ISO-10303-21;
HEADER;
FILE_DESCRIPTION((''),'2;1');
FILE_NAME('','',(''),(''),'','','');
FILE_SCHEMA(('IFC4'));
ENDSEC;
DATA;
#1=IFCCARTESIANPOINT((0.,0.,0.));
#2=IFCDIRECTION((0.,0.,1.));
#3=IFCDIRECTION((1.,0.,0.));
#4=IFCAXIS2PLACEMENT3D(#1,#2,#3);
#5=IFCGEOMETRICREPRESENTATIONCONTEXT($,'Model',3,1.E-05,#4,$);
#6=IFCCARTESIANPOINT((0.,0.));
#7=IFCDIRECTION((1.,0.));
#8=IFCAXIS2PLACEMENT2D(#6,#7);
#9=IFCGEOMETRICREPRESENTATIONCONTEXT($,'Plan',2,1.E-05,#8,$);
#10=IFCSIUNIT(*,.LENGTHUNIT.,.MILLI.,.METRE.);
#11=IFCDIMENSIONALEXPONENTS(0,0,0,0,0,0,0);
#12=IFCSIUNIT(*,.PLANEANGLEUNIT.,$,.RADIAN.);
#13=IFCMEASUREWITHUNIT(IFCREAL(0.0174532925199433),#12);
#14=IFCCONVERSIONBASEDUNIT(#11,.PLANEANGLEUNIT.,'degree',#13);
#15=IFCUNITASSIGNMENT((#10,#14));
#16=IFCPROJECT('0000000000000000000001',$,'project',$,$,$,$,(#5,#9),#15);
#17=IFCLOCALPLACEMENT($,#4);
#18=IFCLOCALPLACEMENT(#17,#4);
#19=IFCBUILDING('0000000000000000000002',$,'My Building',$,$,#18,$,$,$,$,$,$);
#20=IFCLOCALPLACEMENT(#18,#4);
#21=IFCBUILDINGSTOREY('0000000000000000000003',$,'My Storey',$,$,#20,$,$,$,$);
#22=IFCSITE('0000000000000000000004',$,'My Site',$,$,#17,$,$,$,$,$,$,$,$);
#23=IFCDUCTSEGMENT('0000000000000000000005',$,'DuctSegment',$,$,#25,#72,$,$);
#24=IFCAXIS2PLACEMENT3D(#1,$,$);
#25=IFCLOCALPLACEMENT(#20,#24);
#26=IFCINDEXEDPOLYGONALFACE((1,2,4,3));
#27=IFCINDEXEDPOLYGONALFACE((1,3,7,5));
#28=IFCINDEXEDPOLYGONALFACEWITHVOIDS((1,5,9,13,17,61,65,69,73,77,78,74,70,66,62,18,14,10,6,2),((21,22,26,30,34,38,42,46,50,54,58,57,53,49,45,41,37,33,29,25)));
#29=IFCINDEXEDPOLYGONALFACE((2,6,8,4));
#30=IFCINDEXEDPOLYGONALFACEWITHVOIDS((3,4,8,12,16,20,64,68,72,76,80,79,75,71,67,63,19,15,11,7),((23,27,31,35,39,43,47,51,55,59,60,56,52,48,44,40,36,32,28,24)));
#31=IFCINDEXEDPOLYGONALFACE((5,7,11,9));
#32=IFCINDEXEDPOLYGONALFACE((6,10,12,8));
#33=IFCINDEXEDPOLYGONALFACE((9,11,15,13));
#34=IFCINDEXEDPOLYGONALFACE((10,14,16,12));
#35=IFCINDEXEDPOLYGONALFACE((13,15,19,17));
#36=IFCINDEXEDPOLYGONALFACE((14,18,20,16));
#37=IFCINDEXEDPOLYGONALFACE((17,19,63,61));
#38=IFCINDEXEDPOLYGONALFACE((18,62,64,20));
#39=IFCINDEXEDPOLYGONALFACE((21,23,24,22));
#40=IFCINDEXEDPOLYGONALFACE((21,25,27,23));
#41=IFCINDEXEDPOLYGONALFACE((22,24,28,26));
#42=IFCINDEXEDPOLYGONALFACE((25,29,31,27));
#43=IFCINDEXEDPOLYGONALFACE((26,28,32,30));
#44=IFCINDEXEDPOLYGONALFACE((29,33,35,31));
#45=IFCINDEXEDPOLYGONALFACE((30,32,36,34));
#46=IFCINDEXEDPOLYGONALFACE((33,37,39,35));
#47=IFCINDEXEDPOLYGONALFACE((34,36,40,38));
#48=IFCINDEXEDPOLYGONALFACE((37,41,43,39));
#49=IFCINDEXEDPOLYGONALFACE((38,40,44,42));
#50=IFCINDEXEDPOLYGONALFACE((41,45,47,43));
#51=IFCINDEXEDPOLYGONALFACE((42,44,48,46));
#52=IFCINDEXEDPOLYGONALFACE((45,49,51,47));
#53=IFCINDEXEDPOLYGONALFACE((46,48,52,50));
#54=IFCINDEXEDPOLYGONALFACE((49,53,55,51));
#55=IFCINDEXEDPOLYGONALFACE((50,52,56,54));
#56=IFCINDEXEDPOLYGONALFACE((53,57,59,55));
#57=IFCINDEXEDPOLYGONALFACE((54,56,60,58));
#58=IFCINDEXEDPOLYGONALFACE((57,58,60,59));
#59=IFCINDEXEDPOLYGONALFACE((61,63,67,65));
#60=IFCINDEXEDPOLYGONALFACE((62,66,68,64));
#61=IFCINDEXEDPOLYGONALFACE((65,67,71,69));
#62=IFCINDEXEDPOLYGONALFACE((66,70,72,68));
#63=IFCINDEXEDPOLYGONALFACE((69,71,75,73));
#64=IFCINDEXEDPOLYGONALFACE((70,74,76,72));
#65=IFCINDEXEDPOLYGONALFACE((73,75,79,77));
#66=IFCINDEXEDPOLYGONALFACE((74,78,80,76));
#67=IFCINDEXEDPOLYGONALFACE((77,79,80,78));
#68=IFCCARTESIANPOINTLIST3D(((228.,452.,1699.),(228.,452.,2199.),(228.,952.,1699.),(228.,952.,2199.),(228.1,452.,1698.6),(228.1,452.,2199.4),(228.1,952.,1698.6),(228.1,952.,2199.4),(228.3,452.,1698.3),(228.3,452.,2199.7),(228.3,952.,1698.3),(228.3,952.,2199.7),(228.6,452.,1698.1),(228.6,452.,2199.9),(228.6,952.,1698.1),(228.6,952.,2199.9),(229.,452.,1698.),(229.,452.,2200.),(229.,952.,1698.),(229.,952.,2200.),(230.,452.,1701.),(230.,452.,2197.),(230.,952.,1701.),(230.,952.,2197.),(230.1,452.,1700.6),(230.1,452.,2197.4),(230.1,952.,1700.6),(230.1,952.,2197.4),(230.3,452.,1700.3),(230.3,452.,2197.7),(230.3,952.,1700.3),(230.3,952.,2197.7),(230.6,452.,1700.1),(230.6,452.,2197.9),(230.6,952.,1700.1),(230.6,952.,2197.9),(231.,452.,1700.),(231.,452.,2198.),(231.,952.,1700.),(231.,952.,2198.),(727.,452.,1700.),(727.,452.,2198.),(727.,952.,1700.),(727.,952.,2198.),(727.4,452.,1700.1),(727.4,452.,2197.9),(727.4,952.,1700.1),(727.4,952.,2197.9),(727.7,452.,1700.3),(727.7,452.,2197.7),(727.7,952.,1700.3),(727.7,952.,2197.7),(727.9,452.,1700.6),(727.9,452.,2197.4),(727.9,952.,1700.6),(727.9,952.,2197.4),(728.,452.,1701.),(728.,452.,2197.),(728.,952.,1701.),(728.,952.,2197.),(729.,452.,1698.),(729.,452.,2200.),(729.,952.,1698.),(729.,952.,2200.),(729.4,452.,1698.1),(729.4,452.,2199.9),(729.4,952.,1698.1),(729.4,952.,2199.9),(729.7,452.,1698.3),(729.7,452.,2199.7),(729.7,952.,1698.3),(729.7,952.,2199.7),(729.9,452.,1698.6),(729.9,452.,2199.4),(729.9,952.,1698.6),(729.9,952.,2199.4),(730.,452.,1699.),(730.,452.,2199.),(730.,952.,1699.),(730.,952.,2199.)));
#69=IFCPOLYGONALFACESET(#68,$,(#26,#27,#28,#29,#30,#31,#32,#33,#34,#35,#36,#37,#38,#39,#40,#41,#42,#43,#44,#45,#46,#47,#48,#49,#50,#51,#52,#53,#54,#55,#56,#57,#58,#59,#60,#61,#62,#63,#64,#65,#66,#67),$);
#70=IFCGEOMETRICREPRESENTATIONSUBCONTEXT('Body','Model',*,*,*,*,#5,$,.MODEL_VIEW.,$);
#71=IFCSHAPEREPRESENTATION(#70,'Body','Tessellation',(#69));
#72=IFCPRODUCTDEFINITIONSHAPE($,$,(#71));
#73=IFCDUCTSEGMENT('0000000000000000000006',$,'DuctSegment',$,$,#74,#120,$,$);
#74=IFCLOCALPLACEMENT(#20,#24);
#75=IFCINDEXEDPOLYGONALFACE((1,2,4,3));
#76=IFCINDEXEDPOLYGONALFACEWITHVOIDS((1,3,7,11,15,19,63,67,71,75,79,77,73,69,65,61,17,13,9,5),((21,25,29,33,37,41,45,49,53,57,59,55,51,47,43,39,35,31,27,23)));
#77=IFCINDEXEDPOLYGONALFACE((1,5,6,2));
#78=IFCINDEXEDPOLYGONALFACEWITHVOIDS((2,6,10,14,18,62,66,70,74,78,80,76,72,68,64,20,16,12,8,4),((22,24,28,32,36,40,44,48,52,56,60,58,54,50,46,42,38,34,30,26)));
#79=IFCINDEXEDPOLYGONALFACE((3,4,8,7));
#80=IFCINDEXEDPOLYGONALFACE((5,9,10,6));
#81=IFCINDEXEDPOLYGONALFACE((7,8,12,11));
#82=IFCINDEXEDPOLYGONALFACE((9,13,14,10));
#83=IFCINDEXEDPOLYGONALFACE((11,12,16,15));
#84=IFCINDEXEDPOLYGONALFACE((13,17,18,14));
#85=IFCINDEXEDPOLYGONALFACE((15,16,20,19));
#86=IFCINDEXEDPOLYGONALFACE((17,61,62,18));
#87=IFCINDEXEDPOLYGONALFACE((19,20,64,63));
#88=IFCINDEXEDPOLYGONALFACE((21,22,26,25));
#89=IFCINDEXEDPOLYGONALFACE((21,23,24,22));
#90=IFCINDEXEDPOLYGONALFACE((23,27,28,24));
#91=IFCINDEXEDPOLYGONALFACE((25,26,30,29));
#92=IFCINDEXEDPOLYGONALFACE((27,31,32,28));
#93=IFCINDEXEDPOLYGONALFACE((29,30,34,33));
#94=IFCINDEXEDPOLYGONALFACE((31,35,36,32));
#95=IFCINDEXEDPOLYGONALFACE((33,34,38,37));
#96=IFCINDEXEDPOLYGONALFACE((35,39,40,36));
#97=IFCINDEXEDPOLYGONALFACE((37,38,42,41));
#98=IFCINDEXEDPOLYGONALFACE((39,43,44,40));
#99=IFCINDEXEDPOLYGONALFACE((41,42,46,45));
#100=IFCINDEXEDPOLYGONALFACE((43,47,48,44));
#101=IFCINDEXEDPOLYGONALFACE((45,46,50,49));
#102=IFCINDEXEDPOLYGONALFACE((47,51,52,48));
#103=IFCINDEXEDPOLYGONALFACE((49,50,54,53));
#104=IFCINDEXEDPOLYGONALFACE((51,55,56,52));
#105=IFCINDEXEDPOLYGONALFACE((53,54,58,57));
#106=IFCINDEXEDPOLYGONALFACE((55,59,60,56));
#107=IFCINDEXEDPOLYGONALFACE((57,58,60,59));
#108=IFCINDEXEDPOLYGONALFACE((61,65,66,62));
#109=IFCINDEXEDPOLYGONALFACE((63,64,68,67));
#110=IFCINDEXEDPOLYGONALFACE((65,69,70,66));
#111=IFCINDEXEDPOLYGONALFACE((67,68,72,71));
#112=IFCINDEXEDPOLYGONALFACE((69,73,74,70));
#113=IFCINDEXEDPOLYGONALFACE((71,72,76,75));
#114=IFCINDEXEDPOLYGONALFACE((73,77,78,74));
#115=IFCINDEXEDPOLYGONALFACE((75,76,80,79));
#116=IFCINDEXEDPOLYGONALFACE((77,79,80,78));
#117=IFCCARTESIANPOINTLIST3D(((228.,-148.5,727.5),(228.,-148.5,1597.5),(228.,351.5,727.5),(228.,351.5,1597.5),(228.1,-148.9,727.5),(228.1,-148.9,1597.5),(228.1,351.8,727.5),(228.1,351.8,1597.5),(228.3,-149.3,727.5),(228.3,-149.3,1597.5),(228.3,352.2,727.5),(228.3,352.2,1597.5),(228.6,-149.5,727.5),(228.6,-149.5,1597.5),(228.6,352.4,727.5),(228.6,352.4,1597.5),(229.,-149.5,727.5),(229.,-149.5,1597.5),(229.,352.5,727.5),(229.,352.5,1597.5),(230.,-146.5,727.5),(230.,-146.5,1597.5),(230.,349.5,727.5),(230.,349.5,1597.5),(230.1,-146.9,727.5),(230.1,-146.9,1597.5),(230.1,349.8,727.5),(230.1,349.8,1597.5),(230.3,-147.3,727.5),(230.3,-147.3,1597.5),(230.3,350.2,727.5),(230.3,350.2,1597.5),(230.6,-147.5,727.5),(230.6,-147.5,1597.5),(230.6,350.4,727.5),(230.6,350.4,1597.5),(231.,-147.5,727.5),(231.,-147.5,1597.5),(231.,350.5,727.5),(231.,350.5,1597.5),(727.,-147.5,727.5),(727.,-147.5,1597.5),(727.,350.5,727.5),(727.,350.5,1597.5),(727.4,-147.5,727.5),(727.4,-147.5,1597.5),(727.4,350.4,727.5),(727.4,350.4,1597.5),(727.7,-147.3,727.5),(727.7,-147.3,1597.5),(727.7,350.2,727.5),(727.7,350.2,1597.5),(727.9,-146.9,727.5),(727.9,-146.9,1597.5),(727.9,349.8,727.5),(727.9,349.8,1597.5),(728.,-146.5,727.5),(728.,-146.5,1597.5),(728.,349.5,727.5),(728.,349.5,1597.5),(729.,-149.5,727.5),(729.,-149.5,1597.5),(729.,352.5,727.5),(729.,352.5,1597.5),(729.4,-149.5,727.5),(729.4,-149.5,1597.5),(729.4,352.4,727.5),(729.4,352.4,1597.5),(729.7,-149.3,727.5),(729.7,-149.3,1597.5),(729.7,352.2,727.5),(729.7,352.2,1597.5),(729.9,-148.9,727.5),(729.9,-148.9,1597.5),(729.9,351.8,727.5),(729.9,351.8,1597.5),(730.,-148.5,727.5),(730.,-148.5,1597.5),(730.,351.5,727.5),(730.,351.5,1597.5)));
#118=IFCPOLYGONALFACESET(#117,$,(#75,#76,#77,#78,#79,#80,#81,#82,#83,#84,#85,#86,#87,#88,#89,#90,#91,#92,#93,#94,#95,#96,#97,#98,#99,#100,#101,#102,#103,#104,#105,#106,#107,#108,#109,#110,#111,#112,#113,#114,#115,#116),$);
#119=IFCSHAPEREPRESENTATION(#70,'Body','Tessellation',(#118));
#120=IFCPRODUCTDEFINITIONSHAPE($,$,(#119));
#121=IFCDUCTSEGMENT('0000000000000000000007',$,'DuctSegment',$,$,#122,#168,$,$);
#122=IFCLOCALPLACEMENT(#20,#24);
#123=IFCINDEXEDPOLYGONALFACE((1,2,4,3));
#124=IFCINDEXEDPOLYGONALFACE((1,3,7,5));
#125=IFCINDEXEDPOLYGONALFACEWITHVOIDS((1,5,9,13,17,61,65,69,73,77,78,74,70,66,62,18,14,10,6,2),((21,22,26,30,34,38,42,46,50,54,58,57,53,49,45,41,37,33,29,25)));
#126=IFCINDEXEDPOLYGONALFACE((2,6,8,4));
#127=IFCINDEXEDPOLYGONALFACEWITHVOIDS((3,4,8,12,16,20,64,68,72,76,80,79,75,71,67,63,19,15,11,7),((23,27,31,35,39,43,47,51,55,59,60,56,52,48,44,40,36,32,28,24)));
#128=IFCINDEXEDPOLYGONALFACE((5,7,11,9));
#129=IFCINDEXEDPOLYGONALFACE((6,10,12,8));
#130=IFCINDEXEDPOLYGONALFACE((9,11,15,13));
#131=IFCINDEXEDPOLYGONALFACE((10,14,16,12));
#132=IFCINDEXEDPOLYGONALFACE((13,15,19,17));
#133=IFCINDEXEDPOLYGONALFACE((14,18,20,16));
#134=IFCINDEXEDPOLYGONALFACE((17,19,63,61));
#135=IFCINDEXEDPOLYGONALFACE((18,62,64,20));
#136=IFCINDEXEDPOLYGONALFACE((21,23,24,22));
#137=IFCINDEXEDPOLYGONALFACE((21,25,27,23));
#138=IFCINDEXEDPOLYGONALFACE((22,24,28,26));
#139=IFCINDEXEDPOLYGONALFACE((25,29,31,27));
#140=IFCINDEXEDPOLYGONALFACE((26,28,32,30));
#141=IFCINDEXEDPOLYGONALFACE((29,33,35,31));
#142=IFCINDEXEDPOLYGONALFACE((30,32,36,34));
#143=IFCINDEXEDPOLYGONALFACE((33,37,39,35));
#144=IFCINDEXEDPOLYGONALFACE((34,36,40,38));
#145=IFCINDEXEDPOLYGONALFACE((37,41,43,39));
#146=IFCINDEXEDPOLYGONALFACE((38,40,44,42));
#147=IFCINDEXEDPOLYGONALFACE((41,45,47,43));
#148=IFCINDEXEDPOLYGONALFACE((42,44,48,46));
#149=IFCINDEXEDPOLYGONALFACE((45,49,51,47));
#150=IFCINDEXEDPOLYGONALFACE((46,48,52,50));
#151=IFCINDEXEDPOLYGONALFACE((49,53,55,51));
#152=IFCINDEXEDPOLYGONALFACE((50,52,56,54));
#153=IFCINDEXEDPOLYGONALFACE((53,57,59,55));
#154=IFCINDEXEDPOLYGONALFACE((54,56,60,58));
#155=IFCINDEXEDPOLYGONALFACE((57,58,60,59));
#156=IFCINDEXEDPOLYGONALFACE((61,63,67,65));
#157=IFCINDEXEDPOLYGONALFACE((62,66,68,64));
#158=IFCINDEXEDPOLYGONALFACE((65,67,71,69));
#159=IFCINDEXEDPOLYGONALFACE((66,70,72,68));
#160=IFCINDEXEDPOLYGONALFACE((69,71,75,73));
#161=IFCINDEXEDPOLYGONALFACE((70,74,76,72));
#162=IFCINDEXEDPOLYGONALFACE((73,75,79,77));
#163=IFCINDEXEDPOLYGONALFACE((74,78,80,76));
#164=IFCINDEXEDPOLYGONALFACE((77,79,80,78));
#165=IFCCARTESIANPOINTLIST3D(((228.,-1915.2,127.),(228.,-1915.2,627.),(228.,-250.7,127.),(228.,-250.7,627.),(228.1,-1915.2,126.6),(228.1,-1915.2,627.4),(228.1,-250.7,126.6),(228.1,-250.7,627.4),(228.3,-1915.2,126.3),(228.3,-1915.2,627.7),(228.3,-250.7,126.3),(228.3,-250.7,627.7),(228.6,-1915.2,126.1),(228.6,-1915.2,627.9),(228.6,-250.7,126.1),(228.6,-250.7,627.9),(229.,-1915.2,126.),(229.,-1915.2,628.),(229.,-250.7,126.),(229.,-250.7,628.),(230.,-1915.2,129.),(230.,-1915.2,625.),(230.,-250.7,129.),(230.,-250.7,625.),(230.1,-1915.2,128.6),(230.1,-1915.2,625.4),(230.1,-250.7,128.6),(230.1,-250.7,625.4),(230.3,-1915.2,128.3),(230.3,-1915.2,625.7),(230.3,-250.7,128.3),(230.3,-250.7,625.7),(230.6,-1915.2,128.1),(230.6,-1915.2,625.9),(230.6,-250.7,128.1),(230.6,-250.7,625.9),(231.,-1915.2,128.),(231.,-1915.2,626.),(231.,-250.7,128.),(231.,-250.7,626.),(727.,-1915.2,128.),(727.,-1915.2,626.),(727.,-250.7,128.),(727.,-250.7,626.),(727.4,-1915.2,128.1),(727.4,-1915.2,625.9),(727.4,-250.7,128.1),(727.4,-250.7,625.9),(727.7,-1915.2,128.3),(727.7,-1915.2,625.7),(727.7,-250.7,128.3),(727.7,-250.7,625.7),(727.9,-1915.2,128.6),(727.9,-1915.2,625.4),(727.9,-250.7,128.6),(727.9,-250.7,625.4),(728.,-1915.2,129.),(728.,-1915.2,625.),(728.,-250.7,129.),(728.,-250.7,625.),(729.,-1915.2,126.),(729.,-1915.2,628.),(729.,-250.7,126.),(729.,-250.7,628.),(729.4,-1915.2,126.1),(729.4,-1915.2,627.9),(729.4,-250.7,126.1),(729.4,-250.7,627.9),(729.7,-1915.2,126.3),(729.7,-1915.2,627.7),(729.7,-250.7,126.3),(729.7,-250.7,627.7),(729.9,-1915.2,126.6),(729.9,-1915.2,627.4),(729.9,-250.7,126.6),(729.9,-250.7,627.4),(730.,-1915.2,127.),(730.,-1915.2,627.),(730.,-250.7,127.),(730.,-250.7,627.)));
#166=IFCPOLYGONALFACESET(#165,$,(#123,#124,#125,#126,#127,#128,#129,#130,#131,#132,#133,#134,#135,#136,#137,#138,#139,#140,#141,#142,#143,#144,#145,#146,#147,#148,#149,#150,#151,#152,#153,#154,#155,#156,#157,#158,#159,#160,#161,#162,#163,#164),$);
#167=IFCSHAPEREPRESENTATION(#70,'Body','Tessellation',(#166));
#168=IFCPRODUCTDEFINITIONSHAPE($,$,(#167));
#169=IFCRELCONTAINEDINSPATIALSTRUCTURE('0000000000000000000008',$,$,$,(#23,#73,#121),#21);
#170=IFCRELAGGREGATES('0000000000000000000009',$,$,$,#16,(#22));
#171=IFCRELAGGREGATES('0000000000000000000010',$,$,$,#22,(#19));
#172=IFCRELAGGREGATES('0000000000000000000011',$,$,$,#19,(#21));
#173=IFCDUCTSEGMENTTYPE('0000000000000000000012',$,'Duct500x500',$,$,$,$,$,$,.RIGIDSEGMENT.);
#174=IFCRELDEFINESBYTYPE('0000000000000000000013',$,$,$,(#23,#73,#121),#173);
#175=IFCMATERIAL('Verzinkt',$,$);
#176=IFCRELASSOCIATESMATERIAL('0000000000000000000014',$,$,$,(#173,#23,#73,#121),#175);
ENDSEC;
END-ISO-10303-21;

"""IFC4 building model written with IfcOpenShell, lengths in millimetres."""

from ifc_helpers import new_model, entity, si_unit, converted_unit, frame, origin_with_axes, origin_2d_with_axis, place, context, subcontext, project, spatial, hollow_rectangle, extrude, material, material_profile, profile_set, profile_usage, type_object, element, save


model = new_model("IFC4")

# Units and contexts
model_context = context("Model", 3, precision=1e-05, world=origin_with_axes())
plan_context = context("Plan", 2, precision=1e-05, world=origin_2d_with_axis())
body_context = subcontext(model_context, "Body", "Model", "MODEL_VIEW")
ifc_project = project(units=[si_unit("LENGTHUNIT", "METRE", prefix="MILLI"), converted_unit("PLANEANGLEUNIT", "degree", entity("IfcReal", 0.0174532925199433), si_unit("PLANEANGLEUNIT", "RADIAN"), dimensions=[0, 0, 0, 0, 0, 0, 0])], contexts=[model_context, plan_context])

# Site, building, storey
site_placement = place(None, origin_with_axes())
site = spatial("IfcSite", under=ifc_project, at=site_placement, Name="My Site")
building_placement = place(site_placement, origin_with_axes())
building = spatial("IfcBuilding", under=site, at=building_placement, Name="My Building")
storey_placement = place(building_placement, origin_with_axes())
storey = spatial("IfcBuildingStorey", under=building, at=storey_placement, Name="My Storey")

# Shared definitions
ifc_material = material(Name="Verzinkt")

# Duct segments
ifc_material_profile_1 = material_profile(ifc_material, hollow_rectangle(XDim=502.0, YDim=502.0, WallThickness=2.0, InnerFilletRadius=1.0, OuterFilletRadius=1.0))
ifc_profile_set_1 = profile_set([ifc_material_profile_1])
duct_segment_type_1 = type_object("IfcDuctSegmentType", Name="Duct500x500", PredefinedType="RIGIDSEGMENT", material=ifc_profile_set_1)
ifc_profile_usage_1 = profile_usage(ifc_profile_set_1, cardinal=5)
duct_segment_1_placement = place(storey_placement, frame((479.0, 952.0, 1949.0), z_axis=(0.0, -1.0, 0.0), x_axis=(1.0, 0.0, 0.0)))
element("IfcDuctSegment", 1, at=duct_segment_1_placement, inside=storey, type_object=duct_segment_type_1, material=ifc_profile_usage_1, Name="DuctSegment", context=body_context, shape_type="SweptSolid", body=[
    extrude(hollow_rectangle(XDim=502.0, YDim=502.0, WallThickness=2.0, InnerFilletRadius=1.0, OuterFilletRadius=1.0), origin_with_axes(), (0.0, 0.0, 1.0), 500.0),
])
ifc_profile_usage_2 = profile_usage(ifc_profile_set_1, cardinal=5)
duct_segment_2_placement = place(storey_placement, frame((479.0, 101.5, 1597.5), z_axis=(0.0, 0.0, -1.0), x_axis=(1.0, 0.0, 0.0)))
element("IfcDuctSegment", 2, at=duct_segment_2_placement, inside=storey, type_object=duct_segment_type_1, material=ifc_profile_usage_2, Name="DuctSegment", context=body_context, shape_type="SweptSolid", body=[
    extrude(hollow_rectangle(XDim=502.0, YDim=502.0, WallThickness=2.0, InnerFilletRadius=1.0, OuterFilletRadius=1.0), origin_with_axes(), (0.0, 0.0, 1.0), 870.0),
])
ifc_profile_usage_3 = profile_usage(ifc_profile_set_1, cardinal=5)
duct_segment_3_placement = place(storey_placement, frame((479.0, -250.7, 377.0), z_axis=(0.0, -1.0, 0.0), x_axis=(1.0, 0.0, 0.0)))
element("IfcDuctSegment", 3, at=duct_segment_3_placement, inside=storey, type_object=duct_segment_type_1, material=ifc_profile_usage_3, Name="DuctSegment", context=body_context, shape_type="SweptSolid", body=[
    extrude(hollow_rectangle(XDim=502.0, YDim=502.0, WallThickness=2.0, InnerFilletRadius=1.0, OuterFilletRadius=1.0), origin_with_axes(), (0.0, 0.0, 1.0), 1664.5),
])

save(model, "model.ifc")
